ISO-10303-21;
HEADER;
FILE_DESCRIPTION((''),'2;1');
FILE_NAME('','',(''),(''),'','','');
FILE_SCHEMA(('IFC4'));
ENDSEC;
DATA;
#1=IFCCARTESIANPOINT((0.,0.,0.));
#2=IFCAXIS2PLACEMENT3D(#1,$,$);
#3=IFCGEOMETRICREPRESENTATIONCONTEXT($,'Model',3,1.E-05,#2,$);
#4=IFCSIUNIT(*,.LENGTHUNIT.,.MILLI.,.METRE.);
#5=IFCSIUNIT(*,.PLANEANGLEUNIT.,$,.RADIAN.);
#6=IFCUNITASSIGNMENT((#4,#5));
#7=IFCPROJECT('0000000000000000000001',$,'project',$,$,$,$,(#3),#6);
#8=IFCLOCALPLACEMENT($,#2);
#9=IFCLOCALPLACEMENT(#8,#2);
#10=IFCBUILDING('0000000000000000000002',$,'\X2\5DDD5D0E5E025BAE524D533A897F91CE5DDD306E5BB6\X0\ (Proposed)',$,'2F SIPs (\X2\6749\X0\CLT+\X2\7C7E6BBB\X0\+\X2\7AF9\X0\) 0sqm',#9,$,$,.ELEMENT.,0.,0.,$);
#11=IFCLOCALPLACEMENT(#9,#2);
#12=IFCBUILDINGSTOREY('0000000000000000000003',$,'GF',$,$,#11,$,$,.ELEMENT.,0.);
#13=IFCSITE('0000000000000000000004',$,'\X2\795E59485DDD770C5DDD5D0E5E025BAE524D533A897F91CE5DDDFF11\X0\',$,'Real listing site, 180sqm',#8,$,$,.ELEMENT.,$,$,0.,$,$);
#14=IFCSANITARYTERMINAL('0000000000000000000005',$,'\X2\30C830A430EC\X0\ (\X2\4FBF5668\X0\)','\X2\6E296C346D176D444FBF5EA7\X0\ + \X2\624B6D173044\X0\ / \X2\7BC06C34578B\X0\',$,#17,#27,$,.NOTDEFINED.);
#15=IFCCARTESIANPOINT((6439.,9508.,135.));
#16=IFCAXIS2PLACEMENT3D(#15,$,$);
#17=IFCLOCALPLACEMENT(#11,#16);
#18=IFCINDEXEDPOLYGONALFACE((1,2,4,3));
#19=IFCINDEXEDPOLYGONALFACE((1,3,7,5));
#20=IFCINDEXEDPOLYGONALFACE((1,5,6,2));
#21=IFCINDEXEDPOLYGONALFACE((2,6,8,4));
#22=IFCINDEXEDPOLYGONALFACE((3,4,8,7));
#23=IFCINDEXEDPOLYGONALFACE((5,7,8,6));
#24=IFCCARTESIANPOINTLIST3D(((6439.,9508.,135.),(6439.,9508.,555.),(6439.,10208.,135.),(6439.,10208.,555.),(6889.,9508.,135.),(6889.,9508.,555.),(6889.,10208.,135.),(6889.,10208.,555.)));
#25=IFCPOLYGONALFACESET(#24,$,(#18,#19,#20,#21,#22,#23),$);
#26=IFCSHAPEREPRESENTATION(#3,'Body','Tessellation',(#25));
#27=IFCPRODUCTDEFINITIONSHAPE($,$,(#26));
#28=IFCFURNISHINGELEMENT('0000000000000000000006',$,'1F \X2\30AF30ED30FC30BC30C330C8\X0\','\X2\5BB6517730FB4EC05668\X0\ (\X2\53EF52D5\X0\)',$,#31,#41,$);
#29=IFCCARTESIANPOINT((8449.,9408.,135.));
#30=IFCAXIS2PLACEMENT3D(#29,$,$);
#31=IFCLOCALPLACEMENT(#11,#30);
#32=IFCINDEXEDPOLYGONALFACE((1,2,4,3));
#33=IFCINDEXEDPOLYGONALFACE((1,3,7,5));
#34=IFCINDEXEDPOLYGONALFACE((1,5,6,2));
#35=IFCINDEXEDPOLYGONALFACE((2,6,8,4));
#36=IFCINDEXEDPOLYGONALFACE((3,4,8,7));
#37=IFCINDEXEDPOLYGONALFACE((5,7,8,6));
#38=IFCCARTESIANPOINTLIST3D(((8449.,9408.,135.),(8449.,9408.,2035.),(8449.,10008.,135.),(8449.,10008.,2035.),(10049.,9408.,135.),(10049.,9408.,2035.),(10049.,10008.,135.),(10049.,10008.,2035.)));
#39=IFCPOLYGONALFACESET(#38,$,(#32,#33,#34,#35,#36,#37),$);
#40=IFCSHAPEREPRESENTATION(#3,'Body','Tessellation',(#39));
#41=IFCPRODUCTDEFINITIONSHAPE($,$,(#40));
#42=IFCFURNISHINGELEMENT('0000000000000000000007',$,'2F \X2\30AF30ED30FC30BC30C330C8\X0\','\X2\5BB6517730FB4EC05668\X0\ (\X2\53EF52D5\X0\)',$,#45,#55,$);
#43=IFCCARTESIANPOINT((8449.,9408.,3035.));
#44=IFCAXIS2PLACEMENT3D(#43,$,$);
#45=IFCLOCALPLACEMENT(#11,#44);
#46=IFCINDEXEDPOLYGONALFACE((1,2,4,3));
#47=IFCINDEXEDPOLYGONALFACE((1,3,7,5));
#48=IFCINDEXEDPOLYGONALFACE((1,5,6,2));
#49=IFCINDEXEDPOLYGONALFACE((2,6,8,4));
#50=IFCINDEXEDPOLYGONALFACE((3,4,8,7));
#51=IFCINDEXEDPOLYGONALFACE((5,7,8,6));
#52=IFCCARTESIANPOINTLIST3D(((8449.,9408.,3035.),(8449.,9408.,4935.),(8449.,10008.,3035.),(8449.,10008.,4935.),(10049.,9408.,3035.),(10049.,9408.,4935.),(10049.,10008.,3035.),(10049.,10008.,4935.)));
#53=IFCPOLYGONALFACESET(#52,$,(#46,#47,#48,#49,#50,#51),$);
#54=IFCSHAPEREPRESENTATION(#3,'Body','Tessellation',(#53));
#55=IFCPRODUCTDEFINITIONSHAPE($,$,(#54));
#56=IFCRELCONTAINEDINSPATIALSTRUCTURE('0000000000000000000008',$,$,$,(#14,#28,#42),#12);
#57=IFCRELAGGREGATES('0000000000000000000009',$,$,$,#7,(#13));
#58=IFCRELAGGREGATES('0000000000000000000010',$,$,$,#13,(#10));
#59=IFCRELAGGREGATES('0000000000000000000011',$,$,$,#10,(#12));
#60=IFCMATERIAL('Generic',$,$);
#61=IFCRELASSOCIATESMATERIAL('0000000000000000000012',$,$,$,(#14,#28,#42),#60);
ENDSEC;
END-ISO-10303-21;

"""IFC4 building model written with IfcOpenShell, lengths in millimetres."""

from ifc_helpers import new_model, si_unit, frame, frame_2d, origin, place, context, project, spatial, rectangle, extrude, material, element, save


model = new_model("IFC4")

# Units and contexts
model_context = context("Model", 3, precision=1e-05, world=origin())
ifc_project = project(units=[si_unit("LENGTHUNIT", "METRE", prefix="MILLI"), si_unit("PLANEANGLEUNIT", "RADIAN")], contexts=[model_context])

# Site, building, storey
site_placement = place(None, origin())
site = spatial("IfcSite", under=ifc_project, at=site_placement, Name="神奈川県川崎市宮前区西野川１", ObjectType="Real listing site, 180sqm", CompositionType="ELEMENT", RefElevation=0.0)
building_placement = place(site_placement, origin())
building = spatial("IfcBuilding", under=site, at=building_placement, Name="川崎市宮前区西野川の家 (Proposed)", ObjectType="2F SIPs (杉CLT+籾殻+竹) 0sqm", CompositionType="ELEMENT", ElevationOfRefHeight=0.0, ElevationOfTerrain=0.0)
storey_placement = place(building_placement, origin())
storey = spatial("IfcBuildingStorey", under=building, at=storey_placement, Name="GF", CompositionType="ELEMENT", Elevation=0.0)

# Shared definitions
ifc_material_1 = material(Name="Generic")

# Sanitary terminal
sanitary_terminal_1_placement = place(storey_placement, frame((6439.0, 9508.0, 135.0)))
element("IfcSanitaryTerminal", 1, at=sanitary_terminal_1_placement, inside=storey, material=ifc_material_1, Name="トイレ (便器)", Description="温水洗浄便座 + 手洗い / 節水型", PredefinedType="NOTDEFINED", context=model_context, shape_type="SweptSolid", body=[
    extrude(rectangle(XDim=450.0, YDim=700.0, at=frame_2d((225.0, 350.0))), frame((6439.0, 9508.0, 135.0)), (0.0, 0.0, 1.0), 420.0),
])

# Furnishing elements
furnishing_1_placement = place(storey_placement, frame((8449.0, 9408.0, 135.0)))
element("IfcFurnishingElement", 2, at=furnishing_1_placement, inside=storey, material=ifc_material_1, Name="1F クローゼット", Description="家具・什器 (可動)", context=model_context, shape_type="SweptSolid", body=[
    extrude(rectangle(XDim=1600.0, YDim=600.0, at=frame_2d((800.0, 300.0))), frame((8449.0, 9408.0, 135.0)), (0.0, 0.0, 1.0), 1900.0),
])
furnishing_2_placement = place(storey_placement, frame((8449.0, 9408.0, 3035.0)))
element("IfcFurnishingElement", 3, at=furnishing_2_placement, inside=storey, material=ifc_material_1, Name="2F クローゼット", Description="家具・什器 (可動)", context=model_context, shape_type="SweptSolid", body=[
    extrude(rectangle(XDim=1600.0, YDim=600.0, at=frame_2d((800.0, 300.0))), frame((8449.0, 9408.0, 3035.0)), (0.0, 0.0, 1.0), 1900.0),
])

save(model, "model.ifc")
